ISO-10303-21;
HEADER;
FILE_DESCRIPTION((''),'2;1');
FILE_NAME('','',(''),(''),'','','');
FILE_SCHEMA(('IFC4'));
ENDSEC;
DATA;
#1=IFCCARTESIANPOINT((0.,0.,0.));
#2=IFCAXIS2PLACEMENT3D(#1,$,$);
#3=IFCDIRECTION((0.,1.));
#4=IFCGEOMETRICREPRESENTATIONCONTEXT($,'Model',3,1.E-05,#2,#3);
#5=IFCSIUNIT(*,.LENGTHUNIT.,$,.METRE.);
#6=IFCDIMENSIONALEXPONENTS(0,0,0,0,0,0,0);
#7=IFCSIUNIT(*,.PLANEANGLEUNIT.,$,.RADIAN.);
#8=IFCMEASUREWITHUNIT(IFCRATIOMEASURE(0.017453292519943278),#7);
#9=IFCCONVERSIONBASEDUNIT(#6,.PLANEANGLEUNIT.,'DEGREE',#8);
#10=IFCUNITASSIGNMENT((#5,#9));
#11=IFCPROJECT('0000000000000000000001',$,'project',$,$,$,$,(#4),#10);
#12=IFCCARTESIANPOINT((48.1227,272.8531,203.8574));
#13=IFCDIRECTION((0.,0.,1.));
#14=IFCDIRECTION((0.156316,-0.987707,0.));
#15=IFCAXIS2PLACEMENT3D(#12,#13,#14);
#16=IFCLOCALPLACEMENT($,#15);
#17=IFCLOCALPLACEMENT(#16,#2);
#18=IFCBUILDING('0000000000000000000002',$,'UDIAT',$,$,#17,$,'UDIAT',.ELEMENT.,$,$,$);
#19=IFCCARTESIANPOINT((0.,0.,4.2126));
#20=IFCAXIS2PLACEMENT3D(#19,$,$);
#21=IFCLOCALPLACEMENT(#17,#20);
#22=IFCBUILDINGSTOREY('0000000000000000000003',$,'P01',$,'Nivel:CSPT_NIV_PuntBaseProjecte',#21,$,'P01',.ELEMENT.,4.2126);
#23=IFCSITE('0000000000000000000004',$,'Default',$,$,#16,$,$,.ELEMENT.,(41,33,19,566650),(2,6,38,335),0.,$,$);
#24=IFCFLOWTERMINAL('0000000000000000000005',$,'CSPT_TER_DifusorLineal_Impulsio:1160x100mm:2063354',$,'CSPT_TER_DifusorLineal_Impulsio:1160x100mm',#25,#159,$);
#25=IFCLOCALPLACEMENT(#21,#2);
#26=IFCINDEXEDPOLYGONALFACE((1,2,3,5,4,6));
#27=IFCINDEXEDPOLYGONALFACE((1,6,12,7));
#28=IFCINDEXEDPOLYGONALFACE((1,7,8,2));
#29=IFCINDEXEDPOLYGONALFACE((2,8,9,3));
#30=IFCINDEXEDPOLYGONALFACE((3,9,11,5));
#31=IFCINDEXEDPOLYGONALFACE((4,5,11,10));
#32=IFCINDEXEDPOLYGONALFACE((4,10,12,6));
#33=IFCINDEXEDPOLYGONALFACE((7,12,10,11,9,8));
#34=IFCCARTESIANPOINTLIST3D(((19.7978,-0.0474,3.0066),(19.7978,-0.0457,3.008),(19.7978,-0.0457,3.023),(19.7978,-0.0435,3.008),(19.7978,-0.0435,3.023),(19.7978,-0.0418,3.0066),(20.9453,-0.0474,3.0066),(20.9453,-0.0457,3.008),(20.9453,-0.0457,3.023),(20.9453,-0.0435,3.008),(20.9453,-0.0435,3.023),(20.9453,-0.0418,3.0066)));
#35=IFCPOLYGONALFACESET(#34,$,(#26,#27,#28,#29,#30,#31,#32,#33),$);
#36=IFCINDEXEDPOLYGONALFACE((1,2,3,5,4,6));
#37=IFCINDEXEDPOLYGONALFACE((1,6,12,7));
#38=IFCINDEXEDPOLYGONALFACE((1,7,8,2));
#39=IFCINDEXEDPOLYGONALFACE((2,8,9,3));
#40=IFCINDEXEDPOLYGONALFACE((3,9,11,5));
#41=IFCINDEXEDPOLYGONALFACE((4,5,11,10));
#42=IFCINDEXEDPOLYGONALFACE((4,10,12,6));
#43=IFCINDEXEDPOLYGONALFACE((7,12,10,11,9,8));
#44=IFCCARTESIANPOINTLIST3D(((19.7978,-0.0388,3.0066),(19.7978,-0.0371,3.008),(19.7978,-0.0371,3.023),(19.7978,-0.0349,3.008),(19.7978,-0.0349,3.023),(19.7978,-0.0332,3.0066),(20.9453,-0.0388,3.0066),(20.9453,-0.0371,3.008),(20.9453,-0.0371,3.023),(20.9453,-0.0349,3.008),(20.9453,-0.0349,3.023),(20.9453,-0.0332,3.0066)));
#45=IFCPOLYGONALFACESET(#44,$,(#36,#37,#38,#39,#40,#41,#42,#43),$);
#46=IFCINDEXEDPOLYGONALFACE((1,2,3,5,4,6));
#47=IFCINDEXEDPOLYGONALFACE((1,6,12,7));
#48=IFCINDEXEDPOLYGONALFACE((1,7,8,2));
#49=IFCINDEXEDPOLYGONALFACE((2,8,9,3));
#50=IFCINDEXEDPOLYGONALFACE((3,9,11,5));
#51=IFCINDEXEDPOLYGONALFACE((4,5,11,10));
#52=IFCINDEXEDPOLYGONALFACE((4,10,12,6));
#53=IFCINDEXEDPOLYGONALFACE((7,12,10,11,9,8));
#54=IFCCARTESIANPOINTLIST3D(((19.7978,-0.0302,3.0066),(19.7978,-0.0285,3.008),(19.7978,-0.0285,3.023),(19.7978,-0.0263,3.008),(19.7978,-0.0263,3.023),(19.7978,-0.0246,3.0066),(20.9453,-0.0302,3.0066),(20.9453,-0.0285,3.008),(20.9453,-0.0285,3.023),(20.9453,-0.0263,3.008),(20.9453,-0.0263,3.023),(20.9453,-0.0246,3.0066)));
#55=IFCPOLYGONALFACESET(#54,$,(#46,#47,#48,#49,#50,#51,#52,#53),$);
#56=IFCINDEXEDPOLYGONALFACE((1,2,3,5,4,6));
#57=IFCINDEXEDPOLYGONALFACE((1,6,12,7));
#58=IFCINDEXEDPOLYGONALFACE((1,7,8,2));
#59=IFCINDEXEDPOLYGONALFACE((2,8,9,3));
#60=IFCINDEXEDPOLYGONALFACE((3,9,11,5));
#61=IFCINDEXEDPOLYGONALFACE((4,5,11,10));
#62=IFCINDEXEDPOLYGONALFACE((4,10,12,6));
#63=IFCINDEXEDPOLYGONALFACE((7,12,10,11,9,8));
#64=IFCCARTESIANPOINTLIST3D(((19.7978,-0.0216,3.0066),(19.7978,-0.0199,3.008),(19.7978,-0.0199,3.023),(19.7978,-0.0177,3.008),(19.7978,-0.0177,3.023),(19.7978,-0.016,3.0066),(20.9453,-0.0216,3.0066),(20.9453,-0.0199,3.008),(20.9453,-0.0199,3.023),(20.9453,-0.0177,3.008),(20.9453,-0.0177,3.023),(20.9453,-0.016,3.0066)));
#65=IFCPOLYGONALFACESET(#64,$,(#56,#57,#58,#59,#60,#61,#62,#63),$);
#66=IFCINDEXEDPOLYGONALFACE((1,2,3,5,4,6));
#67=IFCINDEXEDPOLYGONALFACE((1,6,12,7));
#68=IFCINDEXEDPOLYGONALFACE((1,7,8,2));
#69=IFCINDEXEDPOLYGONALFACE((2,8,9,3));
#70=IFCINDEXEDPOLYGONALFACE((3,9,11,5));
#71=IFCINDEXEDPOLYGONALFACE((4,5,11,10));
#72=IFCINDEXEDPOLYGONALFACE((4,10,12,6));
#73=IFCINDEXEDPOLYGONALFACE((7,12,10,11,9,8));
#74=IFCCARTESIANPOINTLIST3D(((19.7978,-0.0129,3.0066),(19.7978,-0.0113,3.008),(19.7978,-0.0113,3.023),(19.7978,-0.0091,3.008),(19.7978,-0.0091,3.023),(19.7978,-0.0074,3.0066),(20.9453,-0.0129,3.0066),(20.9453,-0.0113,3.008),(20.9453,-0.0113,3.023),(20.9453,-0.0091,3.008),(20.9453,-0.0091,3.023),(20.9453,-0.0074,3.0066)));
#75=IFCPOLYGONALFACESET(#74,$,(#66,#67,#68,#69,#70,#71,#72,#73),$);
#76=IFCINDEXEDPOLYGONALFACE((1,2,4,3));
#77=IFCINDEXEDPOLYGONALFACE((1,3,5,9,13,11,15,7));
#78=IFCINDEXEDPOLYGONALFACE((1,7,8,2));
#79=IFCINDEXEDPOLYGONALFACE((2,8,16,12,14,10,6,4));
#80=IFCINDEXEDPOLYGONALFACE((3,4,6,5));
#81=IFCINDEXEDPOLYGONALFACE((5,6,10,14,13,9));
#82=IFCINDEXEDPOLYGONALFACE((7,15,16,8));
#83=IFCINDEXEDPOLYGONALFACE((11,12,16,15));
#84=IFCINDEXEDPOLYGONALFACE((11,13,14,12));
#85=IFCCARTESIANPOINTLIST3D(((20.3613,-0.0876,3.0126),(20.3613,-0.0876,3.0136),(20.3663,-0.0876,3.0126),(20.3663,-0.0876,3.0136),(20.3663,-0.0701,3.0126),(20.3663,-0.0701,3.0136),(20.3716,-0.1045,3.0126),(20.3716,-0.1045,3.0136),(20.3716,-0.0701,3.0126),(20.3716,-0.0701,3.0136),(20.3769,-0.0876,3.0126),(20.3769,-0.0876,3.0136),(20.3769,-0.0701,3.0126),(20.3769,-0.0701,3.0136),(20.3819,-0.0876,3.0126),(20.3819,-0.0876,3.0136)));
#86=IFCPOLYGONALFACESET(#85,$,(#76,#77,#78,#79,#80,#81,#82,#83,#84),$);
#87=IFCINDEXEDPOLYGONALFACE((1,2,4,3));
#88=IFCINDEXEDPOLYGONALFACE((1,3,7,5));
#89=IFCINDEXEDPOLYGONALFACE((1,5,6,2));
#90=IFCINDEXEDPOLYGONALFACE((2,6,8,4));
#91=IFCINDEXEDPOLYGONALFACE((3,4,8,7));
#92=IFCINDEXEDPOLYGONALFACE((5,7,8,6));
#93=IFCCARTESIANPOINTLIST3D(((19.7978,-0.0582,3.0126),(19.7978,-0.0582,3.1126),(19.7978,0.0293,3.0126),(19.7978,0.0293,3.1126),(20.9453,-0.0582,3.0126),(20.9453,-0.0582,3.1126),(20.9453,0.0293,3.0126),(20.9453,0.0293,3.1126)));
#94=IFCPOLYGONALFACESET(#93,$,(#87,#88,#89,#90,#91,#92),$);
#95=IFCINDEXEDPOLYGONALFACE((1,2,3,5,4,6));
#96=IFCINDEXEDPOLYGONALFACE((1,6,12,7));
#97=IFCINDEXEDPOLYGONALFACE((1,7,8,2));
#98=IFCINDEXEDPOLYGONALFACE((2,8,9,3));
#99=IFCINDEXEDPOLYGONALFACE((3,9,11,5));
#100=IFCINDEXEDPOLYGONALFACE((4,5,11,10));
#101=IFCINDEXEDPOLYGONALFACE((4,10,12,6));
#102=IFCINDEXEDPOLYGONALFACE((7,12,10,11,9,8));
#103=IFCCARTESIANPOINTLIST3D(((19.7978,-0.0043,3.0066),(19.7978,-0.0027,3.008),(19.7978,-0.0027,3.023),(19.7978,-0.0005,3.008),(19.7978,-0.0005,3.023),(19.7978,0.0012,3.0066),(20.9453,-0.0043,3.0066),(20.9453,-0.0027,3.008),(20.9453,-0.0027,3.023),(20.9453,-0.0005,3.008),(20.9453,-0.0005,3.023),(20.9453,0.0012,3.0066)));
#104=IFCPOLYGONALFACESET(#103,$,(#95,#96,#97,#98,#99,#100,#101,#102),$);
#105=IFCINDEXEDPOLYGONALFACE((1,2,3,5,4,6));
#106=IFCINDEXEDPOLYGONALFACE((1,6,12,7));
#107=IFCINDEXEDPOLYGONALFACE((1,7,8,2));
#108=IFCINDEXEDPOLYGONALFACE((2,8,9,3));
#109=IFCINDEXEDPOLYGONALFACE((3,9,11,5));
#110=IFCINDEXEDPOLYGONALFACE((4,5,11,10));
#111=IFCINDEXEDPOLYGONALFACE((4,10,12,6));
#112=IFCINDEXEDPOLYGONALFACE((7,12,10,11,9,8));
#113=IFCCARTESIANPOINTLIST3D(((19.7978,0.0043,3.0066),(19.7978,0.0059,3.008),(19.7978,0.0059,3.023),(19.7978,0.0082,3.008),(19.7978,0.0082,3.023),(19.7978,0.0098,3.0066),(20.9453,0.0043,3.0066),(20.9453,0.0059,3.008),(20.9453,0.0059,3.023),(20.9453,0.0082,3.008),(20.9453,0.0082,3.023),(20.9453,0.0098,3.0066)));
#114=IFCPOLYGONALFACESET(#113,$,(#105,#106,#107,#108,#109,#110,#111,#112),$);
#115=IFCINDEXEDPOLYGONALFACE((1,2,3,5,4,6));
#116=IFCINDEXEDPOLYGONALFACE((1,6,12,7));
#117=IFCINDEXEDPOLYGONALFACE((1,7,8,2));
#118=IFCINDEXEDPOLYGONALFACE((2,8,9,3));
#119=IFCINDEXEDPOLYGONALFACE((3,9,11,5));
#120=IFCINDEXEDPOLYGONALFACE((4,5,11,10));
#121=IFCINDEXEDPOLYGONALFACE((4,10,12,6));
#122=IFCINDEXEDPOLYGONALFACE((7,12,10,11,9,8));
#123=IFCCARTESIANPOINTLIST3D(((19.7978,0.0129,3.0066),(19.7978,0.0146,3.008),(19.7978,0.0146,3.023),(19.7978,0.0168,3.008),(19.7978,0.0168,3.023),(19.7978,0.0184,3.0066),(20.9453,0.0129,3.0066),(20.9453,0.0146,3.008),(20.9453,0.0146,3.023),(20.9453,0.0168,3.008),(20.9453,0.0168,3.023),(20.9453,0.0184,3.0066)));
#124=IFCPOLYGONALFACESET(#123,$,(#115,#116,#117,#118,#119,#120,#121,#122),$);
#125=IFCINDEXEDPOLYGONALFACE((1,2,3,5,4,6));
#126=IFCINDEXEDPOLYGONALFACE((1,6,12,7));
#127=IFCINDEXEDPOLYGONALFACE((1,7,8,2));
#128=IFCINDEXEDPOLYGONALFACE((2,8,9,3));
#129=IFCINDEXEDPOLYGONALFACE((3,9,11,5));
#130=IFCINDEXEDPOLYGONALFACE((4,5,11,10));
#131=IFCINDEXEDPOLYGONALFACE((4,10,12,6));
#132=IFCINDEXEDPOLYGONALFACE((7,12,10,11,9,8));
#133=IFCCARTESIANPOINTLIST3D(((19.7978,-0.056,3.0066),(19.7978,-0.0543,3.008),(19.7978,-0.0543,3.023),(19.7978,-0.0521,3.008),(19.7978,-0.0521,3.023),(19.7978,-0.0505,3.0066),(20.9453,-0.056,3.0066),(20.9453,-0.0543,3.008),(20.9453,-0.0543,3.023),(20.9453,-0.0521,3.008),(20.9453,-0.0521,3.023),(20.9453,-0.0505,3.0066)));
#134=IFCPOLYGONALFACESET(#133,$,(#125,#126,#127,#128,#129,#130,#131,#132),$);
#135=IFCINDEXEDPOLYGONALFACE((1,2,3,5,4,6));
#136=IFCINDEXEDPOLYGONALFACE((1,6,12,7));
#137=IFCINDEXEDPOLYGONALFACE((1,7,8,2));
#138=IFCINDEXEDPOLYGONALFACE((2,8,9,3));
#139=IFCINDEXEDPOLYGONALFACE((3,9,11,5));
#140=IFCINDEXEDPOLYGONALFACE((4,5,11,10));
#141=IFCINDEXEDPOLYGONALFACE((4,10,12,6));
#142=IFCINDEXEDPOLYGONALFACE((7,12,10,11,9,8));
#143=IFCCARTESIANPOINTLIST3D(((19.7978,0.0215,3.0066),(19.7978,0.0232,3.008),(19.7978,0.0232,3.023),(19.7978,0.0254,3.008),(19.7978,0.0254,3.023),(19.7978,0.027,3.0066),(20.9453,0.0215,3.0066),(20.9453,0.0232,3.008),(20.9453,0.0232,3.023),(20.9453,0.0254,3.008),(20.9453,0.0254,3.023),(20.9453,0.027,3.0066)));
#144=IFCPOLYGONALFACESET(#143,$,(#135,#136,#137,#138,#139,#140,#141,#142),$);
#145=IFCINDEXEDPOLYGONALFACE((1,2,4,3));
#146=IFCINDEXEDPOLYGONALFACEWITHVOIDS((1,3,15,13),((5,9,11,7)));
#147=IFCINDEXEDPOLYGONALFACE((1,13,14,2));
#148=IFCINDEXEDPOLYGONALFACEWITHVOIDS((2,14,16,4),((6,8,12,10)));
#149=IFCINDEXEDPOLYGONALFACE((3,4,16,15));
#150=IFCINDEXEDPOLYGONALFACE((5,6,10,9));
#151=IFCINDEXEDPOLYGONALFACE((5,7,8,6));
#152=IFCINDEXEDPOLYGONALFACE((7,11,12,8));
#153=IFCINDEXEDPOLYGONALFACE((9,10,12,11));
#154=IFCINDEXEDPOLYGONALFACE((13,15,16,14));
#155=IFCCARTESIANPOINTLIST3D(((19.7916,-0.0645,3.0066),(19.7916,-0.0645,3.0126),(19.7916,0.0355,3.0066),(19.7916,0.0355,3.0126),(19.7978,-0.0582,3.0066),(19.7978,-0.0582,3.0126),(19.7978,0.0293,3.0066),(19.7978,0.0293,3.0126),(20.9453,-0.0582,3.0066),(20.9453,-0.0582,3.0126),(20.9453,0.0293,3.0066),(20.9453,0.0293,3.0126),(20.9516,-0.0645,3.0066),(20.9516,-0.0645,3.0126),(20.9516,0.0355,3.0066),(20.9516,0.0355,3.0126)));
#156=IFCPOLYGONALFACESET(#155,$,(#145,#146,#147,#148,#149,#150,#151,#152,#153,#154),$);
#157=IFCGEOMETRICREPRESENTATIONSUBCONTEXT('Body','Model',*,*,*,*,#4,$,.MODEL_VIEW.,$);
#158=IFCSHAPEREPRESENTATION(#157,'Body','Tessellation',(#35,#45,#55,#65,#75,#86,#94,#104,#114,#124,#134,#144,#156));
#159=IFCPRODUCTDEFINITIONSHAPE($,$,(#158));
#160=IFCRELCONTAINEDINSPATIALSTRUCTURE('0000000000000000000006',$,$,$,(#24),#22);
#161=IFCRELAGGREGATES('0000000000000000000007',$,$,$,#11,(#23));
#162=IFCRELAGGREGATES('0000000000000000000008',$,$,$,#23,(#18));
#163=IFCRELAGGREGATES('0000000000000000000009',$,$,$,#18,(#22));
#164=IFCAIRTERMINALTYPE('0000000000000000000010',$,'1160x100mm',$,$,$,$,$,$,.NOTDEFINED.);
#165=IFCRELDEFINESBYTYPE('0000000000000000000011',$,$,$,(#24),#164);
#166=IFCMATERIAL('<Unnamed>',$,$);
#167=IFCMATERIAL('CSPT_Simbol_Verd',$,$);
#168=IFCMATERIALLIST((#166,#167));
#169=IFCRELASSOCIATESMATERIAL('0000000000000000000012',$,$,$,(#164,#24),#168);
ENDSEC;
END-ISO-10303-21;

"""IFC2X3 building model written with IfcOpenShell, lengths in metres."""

from ifc_helpers import new_model, entity, si_unit, converted_unit, direction, frame, origin, origin_2d_with_axis, place, context, subcontext, project, spatial, polyline, rectangle, outline, extrude, source, transform, mapped, material, material_list, type_object, type_shapes, element, save


model = new_model("IFC2X3")

# Units and contexts
model_context = context("Model", 3, precision=1e-05, world=origin(), true_north=direction((0.0, 1.0)))
body_context = subcontext(model_context, "Body", "Model", "MODEL_VIEW")
ifc_project = project(units=[si_unit("LENGTHUNIT", "METRE"), converted_unit("PLANEANGLEUNIT", "DEGREE", entity("IfcRatioMeasure", 0.017453292519943278), si_unit("PLANEANGLEUNIT", "RADIAN"), dimensions=[0, 0, 0, 0, 0, 0, 0])], contexts=[model_context])

# Site, building, storey
site_placement = place(None, frame((48.1227, 272.8531, 203.8574), z_axis=(0.0, 0.0, 1.0), x_axis=(0.156316, -0.987707, 0.0)))
site = spatial("IfcSite", under=ifc_project, at=site_placement, Name="Default", CompositionType="ELEMENT", RefLatitude=(41, 33, 19, 566650), RefLongitude=(2, 6, 38, 335), RefElevation=0.0)
building_placement = place(site_placement, origin())
building = spatial("IfcBuilding", under=site, at=building_placement, Name="UDIAT", LongName="UDIAT", CompositionType="ELEMENT")
storey_placement = place(building_placement, frame((0.0, 0.0, 4.2126)))
storey = spatial("IfcBuildingStorey", under=building, at=storey_placement, Name="P01", ObjectType="Nivel:CSPT_NIV_PuntBaseProjecte", LongName="P01", CompositionType="ELEMENT", Elevation=4.2126)

# Shared definitions
ifc_material_1 = material(Name="<Unnamed>")

# Flow terminal
ifc_material_2 = material(Name="CSPT_Simbol_Verd")
ifc_material_list = material_list([ifc_material_1, ifc_material_2])
air_terminal_type = type_object("IfcAirTerminalType", Name="1160x100mm", PredefinedType="NOTDEFINED", material=ifc_material_list)
shared_shape_1 = source(origin(), body_context, "Body", "SweptSolid", [
    extrude(outline(polyline([(0.0037, 0.0028), (0.0059, 0.0028), (0.0016, 0.0063), (0.002, 0.0042), (-0.0074, -0.0074), (-0.0057, -0.0088), (0.0037, 0.0028)])), frame((-0.5737, 0.0301, -0.0001), z_axis=(1.0, 0.0, 0.0), x_axis=(0.0, -0.776119, -0.630587)), (0.0, 0.0, 1.0), 1.1475),
    extrude(outline(polyline([(0.0037, 0.0028), (0.0059, 0.0028), (0.0016, 0.0063), (0.002, 0.0042), (-0.0074, -0.0074), (-0.0057, -0.0088), (0.0037, 0.0028)])), frame((-0.5737, 0.0215, -0.0001), z_axis=(1.0, 0.0, 0.0), x_axis=(0.0, -0.776119, -0.630587)), (0.0, 0.0, 1.0), 1.1475),
    extrude(outline(polyline([(0.0037, 0.0028), (0.0059, 0.0028), (0.0016, 0.0063), (0.002, 0.0042), (-0.0074, -0.0074), (-0.0057, -0.0088), (0.0037, 0.0028)])), frame((-0.5737, 0.0129, -0.0001), z_axis=(1.0, 0.0, 0.0), x_axis=(0.0, -0.776119, -0.630587)), (0.0, 0.0, 1.0), 1.1475),
    extrude(outline(polyline([(0.0037, 0.0028), (0.0059, 0.0028), (0.0016, 0.0063), (0.002, 0.0042), (-0.0074, -0.0074), (-0.0057, -0.0088), (0.0037, 0.0028)])), frame((-0.5737, 0.0043, -0.0001), z_axis=(1.0, 0.0, 0.0), x_axis=(0.0, -0.776119, -0.630587)), (0.0, 0.0, 1.0), 1.1475),
    extrude(outline(polyline([(0.0037, 0.0028), (0.0059, 0.0028), (0.0016, 0.0063), (0.002, 0.0042), (-0.0074, -0.0074), (-0.0057, -0.0088), (0.0037, 0.0028)])), frame((-0.5737, -0.0043, -0.0001), z_axis=(1.0, 0.0, 0.0), x_axis=(0.0, -0.776119, -0.630587)), (0.0, 0.0, 1.0), 1.1475),
    extrude(outline(polyline([(0.0, -0.013), (0.0053, -0.013), (0.0053, 0.0045), (0.0103, 0.0045), (0.0, 0.0213), (-0.0103, 0.0045), (-0.0053, 0.0045), (-0.0053, -0.013), (0.0, -0.013)])), frame((0.0, 0.0687, 0.0)), (0.0, 0.0, 1.0), 0.001),
    extrude(rectangle(XDim=1.1475, YDim=0.0875, at=origin_2d_with_axis()), frame((0.0, 0.0, 0.0), z_axis=(0.0, 0.0, 1.0), x_axis=(-1.0, 0.0, 0.0)), (0.0, 0.0, 1.0), 0.1),
    extrude(outline(polyline([(0.0037, 0.0028), (0.0059, 0.0028), (0.0016, 0.0063), (0.002, 0.0042), (-0.0074, -0.0074), (-0.0057, -0.0088), (0.0037, 0.0028)])), frame((-0.5737, -0.0129, -0.0001), z_axis=(1.0, 0.0, 0.0), x_axis=(0.0, -0.776119, -0.630587)), (0.0, 0.0, 1.0), 1.1475),
    extrude(outline(polyline([(0.0037, 0.0028), (0.0059, 0.0028), (0.0016, 0.0063), (0.002, 0.0042), (-0.0074, -0.0074), (-0.0057, -0.0088), (0.0037, 0.0028)])), frame((-0.5737, -0.0215, -0.0001), z_axis=(1.0, 0.0, 0.0), x_axis=(0.0, -0.776119, -0.630587)), (0.0, 0.0, 1.0), 1.1475),
    extrude(outline(polyline([(0.0037, 0.0028), (0.0059, 0.0028), (0.0016, 0.0063), (0.002, 0.0042), (-0.0074, -0.0074), (-0.0057, -0.0088), (0.0037, 0.0028)])), frame((-0.5737, -0.0301, -0.0001), z_axis=(1.0, 0.0, 0.0), x_axis=(0.0, -0.776119, -0.630587)), (0.0, 0.0, 1.0), 1.1475),
    extrude(outline(polyline([(0.0037, 0.0028), (0.0059, 0.0028), (0.0016, 0.0063), (0.002, 0.0042), (-0.0074, -0.0074), (-0.0057, -0.0088), (0.0037, 0.0028)])), frame((-0.5737, 0.0388, -0.0001), z_axis=(1.0, 0.0, 0.0), x_axis=(0.0, -0.776119, -0.630587)), (0.0, 0.0, 1.0), 1.1475),
    extrude(outline(polyline([(0.0037, 0.0028), (0.0059, 0.0028), (0.0016, 0.0063), (0.002, 0.0042), (-0.0074, -0.0074), (-0.0057, -0.0088), (0.0037, 0.0028)])), frame((-0.5737, -0.0387, -0.0001), z_axis=(1.0, 0.0, 0.0), x_axis=(0.0, -0.776119, -0.630587)), (0.0, 0.0, 1.0), 1.1475),
    extrude(outline(polyline([(-0.58, -0.05), (0.58, -0.05), (0.58, 0.05), (-0.58, 0.05), (-0.58, -0.05)]), holes=[polyline([(-0.5738, -0.0438), (-0.5738, 0.0437), (0.5737, 0.0437), (0.5737, -0.0438), (-0.5738, -0.0438)])]), frame((0.0, 0.0, -0.006), z_axis=(0.0, 0.0, 1.0), x_axis=(-1.0, 0.0, 0.0)), (0.0, 0.0, 1.0), 0.006),
])
type_shapes(air_terminal_type, [shared_shape_1])
for number, where, z_axis, x_axis, name in (
    (1, (20.3716, -0.0145, 3.0126), (0.0, 0.0, 1.0), (-1.0, 0.0, 0.0), "CSPT_TER_DifusorLineal_Impulsio:1160x100mm:2063354"),
):
    element("IfcFlowTerminal", number, at=place(storey_placement, frame(where, z_axis=z_axis, x_axis=x_axis)), inside=storey, type_object=air_terminal_type, material=ifc_material_list, Name=name, ObjectType="CSPT_TER_DifusorLineal_Impulsio:1160x100mm", context=body_context, shape_type="MappedRepresentation", body=[
        mapped(shared_shape_1, transform((0.0, 0.0, 0.0), scale=1.0)),
    ])

save(model, "model.ifc")
